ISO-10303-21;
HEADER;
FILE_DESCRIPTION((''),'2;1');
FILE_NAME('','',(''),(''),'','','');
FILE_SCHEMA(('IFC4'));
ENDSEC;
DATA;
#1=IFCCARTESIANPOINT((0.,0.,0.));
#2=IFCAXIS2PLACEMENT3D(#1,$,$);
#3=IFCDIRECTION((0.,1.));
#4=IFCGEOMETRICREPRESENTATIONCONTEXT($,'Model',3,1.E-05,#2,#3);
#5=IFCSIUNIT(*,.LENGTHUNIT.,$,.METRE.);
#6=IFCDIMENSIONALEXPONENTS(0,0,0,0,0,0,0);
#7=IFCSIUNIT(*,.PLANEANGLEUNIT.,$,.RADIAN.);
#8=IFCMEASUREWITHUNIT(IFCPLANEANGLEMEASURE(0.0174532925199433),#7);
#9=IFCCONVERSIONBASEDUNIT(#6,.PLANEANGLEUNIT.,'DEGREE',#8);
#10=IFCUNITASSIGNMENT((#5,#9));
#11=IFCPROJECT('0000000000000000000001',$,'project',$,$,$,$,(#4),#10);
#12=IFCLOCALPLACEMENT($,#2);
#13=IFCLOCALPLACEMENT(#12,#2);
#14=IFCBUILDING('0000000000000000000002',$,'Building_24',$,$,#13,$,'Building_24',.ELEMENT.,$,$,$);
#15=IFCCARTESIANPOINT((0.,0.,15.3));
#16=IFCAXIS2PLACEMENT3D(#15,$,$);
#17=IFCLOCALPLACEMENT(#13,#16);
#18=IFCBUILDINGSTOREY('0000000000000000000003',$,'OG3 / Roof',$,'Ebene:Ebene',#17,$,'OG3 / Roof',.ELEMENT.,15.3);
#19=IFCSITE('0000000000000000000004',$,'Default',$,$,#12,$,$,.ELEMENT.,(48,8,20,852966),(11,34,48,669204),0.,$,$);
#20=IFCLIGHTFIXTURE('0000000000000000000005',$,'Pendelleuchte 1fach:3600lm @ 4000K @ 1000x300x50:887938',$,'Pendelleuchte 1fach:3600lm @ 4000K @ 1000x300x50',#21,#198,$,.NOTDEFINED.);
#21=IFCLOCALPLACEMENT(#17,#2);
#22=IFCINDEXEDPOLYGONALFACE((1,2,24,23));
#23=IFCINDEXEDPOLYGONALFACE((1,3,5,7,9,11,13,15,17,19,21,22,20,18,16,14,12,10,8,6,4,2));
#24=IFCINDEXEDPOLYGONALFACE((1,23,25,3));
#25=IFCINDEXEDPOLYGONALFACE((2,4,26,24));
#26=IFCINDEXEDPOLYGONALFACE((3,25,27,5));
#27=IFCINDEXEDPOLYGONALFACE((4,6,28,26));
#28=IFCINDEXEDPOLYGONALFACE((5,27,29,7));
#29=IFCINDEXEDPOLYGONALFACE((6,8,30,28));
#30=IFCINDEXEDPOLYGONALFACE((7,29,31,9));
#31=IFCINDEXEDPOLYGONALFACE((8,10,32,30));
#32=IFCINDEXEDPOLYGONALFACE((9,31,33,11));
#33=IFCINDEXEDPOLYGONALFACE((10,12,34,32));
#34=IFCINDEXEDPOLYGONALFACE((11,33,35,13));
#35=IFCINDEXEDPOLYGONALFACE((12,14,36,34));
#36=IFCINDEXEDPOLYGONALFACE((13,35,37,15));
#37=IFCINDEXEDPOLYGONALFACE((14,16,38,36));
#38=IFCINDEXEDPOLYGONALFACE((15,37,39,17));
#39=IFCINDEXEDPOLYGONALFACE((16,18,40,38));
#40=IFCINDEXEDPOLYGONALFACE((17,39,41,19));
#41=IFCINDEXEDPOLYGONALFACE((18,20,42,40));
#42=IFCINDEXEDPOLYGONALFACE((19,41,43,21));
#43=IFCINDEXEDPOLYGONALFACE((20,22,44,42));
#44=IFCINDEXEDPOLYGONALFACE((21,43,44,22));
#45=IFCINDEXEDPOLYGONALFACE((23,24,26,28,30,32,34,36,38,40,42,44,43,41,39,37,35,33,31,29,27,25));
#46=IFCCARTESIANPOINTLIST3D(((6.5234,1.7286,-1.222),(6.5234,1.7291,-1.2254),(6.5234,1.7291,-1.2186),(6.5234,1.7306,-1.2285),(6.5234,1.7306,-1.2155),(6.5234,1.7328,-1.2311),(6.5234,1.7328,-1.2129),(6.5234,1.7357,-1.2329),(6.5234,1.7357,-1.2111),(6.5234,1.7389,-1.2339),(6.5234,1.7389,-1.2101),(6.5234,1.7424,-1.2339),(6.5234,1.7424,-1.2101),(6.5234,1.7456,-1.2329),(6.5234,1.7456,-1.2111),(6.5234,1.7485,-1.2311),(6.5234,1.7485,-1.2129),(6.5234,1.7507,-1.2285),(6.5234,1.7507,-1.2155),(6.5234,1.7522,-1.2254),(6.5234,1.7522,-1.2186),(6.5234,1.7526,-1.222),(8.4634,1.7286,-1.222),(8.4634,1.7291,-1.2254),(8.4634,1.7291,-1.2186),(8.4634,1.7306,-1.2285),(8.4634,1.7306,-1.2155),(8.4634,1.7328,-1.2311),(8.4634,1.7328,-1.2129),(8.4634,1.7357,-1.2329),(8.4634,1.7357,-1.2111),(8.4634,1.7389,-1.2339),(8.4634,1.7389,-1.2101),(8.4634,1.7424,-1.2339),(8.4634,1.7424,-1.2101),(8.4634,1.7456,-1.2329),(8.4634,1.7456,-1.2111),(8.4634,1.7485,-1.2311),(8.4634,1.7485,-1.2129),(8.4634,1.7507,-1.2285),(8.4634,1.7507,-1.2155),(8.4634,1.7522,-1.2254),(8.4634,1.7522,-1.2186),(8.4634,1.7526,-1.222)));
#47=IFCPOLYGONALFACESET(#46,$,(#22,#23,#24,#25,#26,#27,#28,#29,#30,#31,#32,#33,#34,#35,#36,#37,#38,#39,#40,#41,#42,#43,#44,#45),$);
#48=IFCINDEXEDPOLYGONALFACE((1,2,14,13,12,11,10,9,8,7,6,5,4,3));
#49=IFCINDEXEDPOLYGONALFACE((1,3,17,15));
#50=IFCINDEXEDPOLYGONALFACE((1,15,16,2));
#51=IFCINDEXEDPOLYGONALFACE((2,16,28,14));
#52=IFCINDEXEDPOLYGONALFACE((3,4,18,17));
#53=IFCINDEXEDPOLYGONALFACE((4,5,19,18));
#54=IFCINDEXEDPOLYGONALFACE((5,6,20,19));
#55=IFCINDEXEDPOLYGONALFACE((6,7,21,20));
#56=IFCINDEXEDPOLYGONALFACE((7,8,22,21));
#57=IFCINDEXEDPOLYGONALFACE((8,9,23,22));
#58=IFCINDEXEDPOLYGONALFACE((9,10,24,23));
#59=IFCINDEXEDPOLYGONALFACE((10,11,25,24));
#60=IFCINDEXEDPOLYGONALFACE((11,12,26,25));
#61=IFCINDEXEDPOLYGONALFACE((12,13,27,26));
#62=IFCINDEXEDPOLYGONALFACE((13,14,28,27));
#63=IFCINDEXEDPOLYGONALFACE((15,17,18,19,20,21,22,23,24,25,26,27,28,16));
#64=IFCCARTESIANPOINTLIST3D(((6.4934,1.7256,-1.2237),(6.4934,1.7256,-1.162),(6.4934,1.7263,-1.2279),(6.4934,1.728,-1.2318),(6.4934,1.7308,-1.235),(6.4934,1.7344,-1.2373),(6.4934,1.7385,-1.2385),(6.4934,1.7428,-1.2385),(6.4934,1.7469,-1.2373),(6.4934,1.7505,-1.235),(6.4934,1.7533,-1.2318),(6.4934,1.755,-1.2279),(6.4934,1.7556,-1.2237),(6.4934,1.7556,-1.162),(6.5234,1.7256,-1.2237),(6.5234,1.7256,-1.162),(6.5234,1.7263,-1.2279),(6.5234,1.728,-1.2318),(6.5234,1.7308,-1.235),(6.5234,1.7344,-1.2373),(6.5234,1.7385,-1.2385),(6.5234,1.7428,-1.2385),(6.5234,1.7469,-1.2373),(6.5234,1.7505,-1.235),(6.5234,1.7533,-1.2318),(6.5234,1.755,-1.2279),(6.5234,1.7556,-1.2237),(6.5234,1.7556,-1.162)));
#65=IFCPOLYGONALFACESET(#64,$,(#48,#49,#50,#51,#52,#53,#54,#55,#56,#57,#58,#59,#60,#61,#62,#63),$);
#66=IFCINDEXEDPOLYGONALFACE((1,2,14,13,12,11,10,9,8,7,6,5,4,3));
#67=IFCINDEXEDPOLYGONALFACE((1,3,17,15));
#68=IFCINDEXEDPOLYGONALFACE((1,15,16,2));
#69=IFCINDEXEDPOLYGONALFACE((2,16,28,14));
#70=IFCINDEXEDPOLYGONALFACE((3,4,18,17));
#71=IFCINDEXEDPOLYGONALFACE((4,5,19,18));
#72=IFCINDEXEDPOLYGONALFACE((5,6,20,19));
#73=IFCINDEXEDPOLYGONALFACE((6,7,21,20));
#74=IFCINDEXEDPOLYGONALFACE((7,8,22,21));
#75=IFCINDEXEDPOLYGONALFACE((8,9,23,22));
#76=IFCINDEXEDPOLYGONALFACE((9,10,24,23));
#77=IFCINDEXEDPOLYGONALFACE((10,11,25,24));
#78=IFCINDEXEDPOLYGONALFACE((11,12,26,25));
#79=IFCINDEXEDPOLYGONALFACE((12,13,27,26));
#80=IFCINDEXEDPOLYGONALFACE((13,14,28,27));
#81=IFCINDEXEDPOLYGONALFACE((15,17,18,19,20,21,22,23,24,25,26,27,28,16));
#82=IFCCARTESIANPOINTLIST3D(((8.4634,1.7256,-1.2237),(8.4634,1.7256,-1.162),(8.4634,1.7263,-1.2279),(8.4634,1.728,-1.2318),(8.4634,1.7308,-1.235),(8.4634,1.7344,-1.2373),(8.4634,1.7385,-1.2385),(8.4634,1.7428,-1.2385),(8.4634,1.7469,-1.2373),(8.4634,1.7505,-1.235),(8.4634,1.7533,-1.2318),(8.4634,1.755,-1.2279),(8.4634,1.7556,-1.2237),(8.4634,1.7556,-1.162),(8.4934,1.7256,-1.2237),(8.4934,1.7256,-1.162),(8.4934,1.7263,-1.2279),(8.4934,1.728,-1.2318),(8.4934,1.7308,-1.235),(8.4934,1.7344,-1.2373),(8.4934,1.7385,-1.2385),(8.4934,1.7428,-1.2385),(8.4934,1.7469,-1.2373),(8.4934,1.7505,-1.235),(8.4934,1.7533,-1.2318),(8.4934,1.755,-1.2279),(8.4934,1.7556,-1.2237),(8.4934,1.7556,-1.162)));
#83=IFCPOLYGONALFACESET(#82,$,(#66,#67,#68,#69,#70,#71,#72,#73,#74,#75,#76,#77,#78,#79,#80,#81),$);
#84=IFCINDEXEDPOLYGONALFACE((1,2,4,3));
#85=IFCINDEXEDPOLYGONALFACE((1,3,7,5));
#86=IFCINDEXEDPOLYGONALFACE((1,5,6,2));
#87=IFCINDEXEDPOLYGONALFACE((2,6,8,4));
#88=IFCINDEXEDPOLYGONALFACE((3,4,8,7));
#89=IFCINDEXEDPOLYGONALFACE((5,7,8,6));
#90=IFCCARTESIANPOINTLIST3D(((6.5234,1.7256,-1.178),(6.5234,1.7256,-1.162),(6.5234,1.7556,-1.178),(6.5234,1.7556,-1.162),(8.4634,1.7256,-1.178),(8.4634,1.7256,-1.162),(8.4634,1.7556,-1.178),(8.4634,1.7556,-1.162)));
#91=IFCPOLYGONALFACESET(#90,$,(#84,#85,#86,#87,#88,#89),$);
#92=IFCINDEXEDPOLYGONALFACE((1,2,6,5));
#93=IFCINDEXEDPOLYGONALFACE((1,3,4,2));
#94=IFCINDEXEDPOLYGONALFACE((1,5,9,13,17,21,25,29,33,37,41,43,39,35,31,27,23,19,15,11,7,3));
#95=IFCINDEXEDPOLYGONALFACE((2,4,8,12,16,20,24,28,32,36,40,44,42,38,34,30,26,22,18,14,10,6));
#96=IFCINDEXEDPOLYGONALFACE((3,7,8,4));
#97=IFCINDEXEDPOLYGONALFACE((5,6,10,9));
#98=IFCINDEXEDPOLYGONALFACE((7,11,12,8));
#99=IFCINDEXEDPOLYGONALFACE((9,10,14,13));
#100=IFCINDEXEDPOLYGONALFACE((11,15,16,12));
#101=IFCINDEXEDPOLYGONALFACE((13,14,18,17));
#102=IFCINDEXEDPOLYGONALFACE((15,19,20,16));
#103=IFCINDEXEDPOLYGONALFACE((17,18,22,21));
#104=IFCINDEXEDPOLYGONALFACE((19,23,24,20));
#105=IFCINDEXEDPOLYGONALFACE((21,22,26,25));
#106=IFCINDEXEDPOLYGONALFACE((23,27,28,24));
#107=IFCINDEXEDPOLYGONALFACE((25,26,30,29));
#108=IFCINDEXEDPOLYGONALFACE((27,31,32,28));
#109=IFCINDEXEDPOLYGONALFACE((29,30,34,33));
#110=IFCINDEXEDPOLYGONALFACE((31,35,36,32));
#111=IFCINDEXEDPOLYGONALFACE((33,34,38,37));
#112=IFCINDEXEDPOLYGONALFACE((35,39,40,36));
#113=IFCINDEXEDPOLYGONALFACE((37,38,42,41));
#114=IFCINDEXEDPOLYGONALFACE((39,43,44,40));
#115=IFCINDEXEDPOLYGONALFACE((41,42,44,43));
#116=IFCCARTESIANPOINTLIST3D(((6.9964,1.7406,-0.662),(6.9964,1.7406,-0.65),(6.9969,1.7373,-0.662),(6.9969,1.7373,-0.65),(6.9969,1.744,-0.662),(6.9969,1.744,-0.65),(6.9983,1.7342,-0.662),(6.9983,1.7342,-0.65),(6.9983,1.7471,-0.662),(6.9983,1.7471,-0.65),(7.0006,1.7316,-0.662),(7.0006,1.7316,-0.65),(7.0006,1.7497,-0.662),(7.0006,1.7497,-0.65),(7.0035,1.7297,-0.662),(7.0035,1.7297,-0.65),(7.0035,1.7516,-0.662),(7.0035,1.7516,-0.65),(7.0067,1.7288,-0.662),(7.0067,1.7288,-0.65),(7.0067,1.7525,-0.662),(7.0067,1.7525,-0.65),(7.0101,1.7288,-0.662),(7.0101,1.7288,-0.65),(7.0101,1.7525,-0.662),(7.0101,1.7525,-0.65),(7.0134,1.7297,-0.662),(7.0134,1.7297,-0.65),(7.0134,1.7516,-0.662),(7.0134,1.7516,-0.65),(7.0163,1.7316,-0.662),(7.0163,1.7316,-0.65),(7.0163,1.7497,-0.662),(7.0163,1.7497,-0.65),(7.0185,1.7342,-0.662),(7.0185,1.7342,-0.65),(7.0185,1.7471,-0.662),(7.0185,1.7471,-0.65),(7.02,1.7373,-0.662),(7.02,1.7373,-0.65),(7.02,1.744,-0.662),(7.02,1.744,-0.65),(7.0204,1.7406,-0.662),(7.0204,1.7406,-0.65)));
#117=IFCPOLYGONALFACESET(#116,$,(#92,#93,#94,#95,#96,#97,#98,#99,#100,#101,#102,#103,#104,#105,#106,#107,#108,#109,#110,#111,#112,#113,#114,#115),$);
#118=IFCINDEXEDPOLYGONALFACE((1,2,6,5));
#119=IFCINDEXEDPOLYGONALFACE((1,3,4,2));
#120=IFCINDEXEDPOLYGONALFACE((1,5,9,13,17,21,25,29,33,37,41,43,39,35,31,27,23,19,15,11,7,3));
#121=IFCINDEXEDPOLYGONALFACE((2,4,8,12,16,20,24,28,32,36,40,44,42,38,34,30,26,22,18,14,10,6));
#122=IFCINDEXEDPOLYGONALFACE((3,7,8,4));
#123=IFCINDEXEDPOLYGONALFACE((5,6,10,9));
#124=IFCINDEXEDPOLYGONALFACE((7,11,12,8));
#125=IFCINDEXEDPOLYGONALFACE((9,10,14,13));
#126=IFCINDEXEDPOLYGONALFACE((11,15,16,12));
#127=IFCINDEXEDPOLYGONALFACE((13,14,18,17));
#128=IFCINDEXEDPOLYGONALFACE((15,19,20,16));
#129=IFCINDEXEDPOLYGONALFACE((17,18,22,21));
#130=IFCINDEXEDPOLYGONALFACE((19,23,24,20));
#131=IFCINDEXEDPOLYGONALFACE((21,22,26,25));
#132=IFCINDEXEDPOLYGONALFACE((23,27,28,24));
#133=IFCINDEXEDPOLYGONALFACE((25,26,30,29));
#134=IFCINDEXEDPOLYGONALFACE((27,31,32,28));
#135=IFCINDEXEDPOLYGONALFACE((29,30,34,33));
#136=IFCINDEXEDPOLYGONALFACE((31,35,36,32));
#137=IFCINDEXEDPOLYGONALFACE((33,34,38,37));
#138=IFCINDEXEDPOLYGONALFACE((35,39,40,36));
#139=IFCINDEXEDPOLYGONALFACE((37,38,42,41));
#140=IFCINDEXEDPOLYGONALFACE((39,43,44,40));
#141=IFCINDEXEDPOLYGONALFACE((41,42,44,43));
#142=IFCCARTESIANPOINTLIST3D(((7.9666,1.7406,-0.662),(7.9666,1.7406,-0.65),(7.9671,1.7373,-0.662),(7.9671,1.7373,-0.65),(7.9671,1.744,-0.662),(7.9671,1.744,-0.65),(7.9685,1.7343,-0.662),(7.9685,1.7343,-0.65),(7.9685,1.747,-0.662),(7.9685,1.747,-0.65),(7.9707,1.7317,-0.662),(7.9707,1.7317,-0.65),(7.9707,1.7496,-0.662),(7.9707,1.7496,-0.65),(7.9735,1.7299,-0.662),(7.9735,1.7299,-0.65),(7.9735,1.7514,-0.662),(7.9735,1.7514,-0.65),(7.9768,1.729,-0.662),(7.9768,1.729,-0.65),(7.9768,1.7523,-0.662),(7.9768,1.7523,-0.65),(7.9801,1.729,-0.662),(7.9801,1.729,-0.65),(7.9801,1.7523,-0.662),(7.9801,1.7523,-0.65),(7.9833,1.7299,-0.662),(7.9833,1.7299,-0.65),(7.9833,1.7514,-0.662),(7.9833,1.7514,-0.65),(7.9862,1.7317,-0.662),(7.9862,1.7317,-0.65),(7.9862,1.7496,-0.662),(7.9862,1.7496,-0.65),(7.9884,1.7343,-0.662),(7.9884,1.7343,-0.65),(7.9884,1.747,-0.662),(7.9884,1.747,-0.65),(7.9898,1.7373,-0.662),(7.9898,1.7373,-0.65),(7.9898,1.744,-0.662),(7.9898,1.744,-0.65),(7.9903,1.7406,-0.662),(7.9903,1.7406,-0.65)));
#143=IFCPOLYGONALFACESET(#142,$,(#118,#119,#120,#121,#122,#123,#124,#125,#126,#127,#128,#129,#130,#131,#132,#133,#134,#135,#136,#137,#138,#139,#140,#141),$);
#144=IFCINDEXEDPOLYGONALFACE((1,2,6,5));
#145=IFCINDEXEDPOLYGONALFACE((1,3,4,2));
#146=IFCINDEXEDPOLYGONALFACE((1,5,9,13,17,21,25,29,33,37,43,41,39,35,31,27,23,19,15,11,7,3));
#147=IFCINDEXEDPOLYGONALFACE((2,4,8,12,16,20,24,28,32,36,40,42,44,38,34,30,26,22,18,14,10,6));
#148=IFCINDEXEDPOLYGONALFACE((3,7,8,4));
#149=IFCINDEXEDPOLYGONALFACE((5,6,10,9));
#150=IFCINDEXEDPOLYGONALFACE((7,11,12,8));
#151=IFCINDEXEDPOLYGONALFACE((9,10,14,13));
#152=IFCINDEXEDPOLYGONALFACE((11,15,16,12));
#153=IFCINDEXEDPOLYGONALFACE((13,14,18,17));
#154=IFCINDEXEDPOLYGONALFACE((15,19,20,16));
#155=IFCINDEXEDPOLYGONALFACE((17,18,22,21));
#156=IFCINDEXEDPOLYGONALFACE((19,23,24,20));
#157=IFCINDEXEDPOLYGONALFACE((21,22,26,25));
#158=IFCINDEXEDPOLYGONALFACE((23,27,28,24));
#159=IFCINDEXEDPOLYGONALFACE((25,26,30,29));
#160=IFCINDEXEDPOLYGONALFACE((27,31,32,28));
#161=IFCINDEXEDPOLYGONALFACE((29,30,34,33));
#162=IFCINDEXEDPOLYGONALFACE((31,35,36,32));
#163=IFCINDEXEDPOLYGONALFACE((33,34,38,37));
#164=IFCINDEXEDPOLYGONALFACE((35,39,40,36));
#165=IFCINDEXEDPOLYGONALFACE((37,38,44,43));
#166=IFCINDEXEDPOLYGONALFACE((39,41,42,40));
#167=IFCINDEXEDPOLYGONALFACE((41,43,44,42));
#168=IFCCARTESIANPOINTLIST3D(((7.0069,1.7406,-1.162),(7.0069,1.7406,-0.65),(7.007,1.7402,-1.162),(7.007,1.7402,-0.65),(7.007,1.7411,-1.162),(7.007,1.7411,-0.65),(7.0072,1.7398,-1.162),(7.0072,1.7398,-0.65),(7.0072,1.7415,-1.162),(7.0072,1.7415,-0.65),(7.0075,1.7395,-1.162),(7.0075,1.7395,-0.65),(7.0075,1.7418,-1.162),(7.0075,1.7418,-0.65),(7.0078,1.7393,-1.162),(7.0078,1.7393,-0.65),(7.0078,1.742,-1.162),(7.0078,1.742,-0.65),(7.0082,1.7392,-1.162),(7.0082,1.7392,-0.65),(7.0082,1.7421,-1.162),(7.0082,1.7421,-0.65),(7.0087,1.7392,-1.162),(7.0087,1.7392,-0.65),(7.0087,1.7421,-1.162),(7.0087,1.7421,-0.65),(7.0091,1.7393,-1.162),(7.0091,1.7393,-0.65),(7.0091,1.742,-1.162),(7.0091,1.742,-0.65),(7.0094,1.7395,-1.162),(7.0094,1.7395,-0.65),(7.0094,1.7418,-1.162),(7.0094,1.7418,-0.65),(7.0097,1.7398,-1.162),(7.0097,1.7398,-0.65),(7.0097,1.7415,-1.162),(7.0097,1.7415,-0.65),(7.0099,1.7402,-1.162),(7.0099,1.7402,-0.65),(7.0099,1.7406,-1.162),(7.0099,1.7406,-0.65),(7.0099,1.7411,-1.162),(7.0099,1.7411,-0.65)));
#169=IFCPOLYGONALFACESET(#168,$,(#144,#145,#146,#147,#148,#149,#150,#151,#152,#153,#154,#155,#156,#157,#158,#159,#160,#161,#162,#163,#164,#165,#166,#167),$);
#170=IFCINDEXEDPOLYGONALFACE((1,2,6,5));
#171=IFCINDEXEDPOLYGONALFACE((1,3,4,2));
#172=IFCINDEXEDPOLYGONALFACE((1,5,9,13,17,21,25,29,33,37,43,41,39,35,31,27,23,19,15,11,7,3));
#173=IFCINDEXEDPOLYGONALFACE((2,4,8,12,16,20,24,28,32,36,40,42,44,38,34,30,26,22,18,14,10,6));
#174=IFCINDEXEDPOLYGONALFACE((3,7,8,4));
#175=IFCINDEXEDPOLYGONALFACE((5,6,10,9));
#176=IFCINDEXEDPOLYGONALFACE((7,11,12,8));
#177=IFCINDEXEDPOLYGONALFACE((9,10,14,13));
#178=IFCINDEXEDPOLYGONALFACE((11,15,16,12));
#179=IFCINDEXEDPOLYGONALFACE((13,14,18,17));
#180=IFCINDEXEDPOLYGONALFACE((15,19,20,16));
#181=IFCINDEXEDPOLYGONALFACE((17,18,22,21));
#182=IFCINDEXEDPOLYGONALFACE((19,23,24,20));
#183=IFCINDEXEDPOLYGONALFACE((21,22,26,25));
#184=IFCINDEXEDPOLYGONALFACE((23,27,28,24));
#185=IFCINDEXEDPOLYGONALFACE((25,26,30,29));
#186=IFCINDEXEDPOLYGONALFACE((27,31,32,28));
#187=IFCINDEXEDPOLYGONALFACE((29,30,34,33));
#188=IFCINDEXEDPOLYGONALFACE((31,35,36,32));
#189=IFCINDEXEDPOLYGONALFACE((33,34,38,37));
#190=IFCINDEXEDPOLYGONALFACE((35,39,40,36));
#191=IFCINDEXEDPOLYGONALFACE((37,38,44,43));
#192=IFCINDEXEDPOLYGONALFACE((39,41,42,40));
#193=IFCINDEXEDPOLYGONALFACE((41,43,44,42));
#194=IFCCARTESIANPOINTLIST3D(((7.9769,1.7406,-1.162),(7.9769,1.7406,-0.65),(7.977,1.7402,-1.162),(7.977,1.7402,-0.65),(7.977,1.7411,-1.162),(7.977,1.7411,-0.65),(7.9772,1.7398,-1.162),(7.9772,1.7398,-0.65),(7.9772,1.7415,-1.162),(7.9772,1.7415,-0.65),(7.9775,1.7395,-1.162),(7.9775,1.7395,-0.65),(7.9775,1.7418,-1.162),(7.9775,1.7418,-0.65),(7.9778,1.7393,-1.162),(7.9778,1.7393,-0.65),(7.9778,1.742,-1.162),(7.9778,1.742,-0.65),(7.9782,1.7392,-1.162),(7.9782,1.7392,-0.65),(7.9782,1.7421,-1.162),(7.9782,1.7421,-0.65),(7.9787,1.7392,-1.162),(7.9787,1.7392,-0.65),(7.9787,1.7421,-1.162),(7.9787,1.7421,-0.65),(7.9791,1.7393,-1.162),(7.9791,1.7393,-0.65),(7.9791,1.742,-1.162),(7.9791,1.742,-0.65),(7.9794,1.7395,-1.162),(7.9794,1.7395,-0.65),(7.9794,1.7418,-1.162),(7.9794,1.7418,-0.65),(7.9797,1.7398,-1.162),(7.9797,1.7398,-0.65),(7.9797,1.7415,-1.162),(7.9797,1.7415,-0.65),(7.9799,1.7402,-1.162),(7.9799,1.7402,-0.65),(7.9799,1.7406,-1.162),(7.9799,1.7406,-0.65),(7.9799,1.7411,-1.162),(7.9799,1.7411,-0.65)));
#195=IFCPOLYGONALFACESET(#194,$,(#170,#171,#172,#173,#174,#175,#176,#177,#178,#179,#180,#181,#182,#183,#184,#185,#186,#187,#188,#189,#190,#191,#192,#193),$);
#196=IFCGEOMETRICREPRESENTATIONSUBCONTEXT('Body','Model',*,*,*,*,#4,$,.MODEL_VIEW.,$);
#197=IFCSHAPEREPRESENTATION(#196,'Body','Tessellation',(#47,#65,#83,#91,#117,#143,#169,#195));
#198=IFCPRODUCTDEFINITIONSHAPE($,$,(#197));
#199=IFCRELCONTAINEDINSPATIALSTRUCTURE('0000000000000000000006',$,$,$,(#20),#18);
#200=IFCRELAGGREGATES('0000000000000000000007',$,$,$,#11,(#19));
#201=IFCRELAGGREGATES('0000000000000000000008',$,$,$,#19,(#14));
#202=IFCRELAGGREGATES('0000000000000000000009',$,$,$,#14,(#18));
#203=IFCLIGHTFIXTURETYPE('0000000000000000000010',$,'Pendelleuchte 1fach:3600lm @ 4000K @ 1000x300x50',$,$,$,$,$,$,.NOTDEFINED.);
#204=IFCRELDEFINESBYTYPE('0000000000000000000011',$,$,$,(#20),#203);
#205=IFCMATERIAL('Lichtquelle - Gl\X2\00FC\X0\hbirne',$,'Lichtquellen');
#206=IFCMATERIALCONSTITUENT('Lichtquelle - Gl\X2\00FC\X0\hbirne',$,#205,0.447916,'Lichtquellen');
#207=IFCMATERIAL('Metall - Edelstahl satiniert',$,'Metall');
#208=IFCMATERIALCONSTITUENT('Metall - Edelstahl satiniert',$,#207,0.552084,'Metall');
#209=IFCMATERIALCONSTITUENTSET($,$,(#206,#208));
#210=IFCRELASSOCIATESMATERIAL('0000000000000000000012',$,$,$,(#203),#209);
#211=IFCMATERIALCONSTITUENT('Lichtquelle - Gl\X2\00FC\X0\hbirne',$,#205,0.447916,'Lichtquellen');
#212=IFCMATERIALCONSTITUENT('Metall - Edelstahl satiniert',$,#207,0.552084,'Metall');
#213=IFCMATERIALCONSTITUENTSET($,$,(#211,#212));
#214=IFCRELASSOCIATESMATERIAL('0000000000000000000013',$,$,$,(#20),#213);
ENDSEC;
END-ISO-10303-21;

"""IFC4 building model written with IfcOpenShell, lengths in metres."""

from ifc_helpers import new_model, entity, si_unit, converted_unit, direction, frame, origin, place, context, subcontext, project, spatial, line, arc, indexed_curve, outline, extrude, source, transform, mapped, material, constituent, constituent_set, type_object, type_shapes, element, save


model = new_model("IFC4")

# Units and contexts
model_context = context("Model", 3, precision=1e-05, world=origin(), true_north=direction((0.0, 1.0)))
body_context = subcontext(model_context, "Body", "Model", "MODEL_VIEW")
ifc_project = project(units=[si_unit("LENGTHUNIT", "METRE"), converted_unit("PLANEANGLEUNIT", "DEGREE", entity("IfcPlaneAngleMeasure", 0.0174532925199433), si_unit("PLANEANGLEUNIT", "RADIAN"), dimensions=[0, 0, 0, 0, 0, 0, 0])], contexts=[model_context])

# Site, building, storey
site_placement = place(None, origin())
site = spatial("IfcSite", under=ifc_project, at=site_placement, Name="Default", CompositionType="ELEMENT", RefLatitude=(48, 8, 20, 852966), RefLongitude=(11, 34, 48, 669204), RefElevation=0.0)
building_placement = place(site_placement, origin())
building = spatial("IfcBuilding", under=site, at=building_placement, Name="Building_24", LongName="Building_24", CompositionType="ELEMENT")
storey_placement = place(building_placement, frame((0.0, 0.0, 15.3)))
storey = spatial("IfcBuildingStorey", under=building, at=storey_placement, Name="OG3 / Roof", ObjectType="Ebene:Ebene", LongName="OG3 / Roof", CompositionType="ELEMENT", Elevation=15.3)

# Light fixture
ifc_material_1 = material(Name="Lichtquelle - Glühbirne", Category="Lichtquellen")
ifc_material_2 = material(Name="Metall - Edelstahl satiniert", Category="Metall")
ifc_constituent_1 = constituent(ifc_material_1, Name="Lichtquelle - Glühbirne", Category="Lichtquellen", fraction=0.447916)
ifc_constituent_2 = constituent(ifc_material_2, Name="Metall - Edelstahl satiniert", Category="Metall", fraction=0.552084)
ifc_constituent_set_1 = constituent_set(constituents=[ifc_constituent_1, ifc_constituent_2])
ifc_constituent_3 = constituent(ifc_material_1, Name="Lichtquelle - Glühbirne", Category="Lichtquellen", fraction=0.447916)
ifc_constituent_4 = constituent(ifc_material_2, Name="Metall - Edelstahl satiniert", Category="Metall", fraction=0.552084)
ifc_constituent_set_2 = constituent_set(constituents=[ifc_constituent_3, ifc_constituent_4])
light_fixture_type_1 = type_object("IfcLightFixtureType", Name="Pendelleuchte 1fach:3600lm @ 4000K @ 1000x300x50", PredefinedType="NOTDEFINED", material=ifc_constituent_set_2)
shared_shape_1 = source(origin(), body_context, "Body", "SweptSolid", [
    extrude(outline(indexed_curve([(-0.012, 0.0), (0.0, -0.012), (0.012, 0.0), (0.0, 0.012)], segments=[arc(1, 2, 3), arc(3, 4, 1)], self_intersect=False)), frame((-0.97, 0.0, -0.572), z_axis=(1.0, 0.0, 0.0), x_axis=(0.0, -1.0, 0.0)), (0.0, 0.0, 1.0), 1.94),
    extrude(outline(indexed_curve([(0.015, 0.0308), (0.0, 0.0458), (-0.015, 0.0308), (-0.015, -0.0308), (0.015, -0.0308)], segments=[arc(1, 2, 3), line(3, 4, 5, 1)], self_intersect=False)), frame((0.97, 0.0, -0.5428), z_axis=(1.0, 0.0, 0.0), x_axis=(0.0, -1.0, 0.0)), (0.0, 0.0, 1.0), 0.03),
    extrude(outline(indexed_curve([(0.015, 0.0308), (0.0, 0.0458), (-0.015, 0.0308), (-0.015, -0.0308), (0.015, -0.0308)], segments=[arc(1, 2, 3), line(3, 4, 5, 1)], self_intersect=False)), frame((-1.0, 0.0, -0.5428), z_axis=(1.0, 0.0, 0.0), x_axis=(0.0, -1.0, 0.0)), (0.0, 0.0, 1.0), 0.03),
    extrude(outline(indexed_curve([(-0.015, -0.97), (0.015, -0.97), (0.015, 0.97), (-0.015, 0.97), (-0.015, -0.97)], self_intersect=False)), frame((0.0, 0.0, -0.528), z_axis=(0.0, 0.0, 1.0), x_axis=(0.0, 1.0, 0.0)), (0.0, 0.0, 1.0), 0.016),
    extrude(outline(indexed_curve([(-0.012, 0.0), (0.0, -0.012), (0.012, 0.0), (0.0, 0.012)], segments=[arc(1, 2, 3), arc(3, 4, 1)], self_intersect=False)), frame((0.485, 0.0, -0.012)), (0.0, 0.0, 1.0), 0.012),
    extrude(outline(indexed_curve([(-0.0118, 0.0), (0.0, -0.0118), (0.0118, 0.0), (0.0, 0.0118)], segments=[arc(1, 2, 3), arc(3, 4, 1)], self_intersect=False)), frame((-0.485, 0.0, -0.012)), (0.0, 0.0, 1.0), 0.012),
    extrude(outline(indexed_curve([(-0.0015, 0.0), (0.0, -0.0015), (0.0015, 0.0), (0.0, 0.0015)], segments=[arc(1, 2, 3), arc(3, 4, 1)], self_intersect=False)), frame((0.485, 0.0, -0.512)), (0.0, 0.0, 1.0), 0.512),
    extrude(outline(indexed_curve([(-0.0015, 0.0), (0.0, -0.0015), (0.0015, 0.0), (0.0, 0.0015)], segments=[arc(1, 2, 3), arc(3, 4, 1)], self_intersect=False)), frame((-0.485, 0.0, -0.512)), (0.0, 0.0, 1.0), 0.512),
])
type_shapes(light_fixture_type_1, [shared_shape_1])
light_fixture_1_placement = place(storey_placement, frame((7.4934, 1.7406, -0.65), z_axis=(0.0, 0.0, 1.0), x_axis=(-1.0, 0.0, 0.0)))
element("IfcLightFixture", 1, at=light_fixture_1_placement, inside=storey, type_object=light_fixture_type_1, material=ifc_constituent_set_1, Name="Pendelleuchte 1fach:3600lm @ 4000K @ 1000x300x50:887938", ObjectType="Pendelleuchte 1fach:3600lm @ 4000K @ 1000x300x50", PredefinedType="NOTDEFINED", context=body_context, shape_type="MappedRepresentation", body=[
    mapped(shared_shape_1, transform((0.0, 0.0, 0.0), scale=1.0)),
])

save(model, "model.ifc")
